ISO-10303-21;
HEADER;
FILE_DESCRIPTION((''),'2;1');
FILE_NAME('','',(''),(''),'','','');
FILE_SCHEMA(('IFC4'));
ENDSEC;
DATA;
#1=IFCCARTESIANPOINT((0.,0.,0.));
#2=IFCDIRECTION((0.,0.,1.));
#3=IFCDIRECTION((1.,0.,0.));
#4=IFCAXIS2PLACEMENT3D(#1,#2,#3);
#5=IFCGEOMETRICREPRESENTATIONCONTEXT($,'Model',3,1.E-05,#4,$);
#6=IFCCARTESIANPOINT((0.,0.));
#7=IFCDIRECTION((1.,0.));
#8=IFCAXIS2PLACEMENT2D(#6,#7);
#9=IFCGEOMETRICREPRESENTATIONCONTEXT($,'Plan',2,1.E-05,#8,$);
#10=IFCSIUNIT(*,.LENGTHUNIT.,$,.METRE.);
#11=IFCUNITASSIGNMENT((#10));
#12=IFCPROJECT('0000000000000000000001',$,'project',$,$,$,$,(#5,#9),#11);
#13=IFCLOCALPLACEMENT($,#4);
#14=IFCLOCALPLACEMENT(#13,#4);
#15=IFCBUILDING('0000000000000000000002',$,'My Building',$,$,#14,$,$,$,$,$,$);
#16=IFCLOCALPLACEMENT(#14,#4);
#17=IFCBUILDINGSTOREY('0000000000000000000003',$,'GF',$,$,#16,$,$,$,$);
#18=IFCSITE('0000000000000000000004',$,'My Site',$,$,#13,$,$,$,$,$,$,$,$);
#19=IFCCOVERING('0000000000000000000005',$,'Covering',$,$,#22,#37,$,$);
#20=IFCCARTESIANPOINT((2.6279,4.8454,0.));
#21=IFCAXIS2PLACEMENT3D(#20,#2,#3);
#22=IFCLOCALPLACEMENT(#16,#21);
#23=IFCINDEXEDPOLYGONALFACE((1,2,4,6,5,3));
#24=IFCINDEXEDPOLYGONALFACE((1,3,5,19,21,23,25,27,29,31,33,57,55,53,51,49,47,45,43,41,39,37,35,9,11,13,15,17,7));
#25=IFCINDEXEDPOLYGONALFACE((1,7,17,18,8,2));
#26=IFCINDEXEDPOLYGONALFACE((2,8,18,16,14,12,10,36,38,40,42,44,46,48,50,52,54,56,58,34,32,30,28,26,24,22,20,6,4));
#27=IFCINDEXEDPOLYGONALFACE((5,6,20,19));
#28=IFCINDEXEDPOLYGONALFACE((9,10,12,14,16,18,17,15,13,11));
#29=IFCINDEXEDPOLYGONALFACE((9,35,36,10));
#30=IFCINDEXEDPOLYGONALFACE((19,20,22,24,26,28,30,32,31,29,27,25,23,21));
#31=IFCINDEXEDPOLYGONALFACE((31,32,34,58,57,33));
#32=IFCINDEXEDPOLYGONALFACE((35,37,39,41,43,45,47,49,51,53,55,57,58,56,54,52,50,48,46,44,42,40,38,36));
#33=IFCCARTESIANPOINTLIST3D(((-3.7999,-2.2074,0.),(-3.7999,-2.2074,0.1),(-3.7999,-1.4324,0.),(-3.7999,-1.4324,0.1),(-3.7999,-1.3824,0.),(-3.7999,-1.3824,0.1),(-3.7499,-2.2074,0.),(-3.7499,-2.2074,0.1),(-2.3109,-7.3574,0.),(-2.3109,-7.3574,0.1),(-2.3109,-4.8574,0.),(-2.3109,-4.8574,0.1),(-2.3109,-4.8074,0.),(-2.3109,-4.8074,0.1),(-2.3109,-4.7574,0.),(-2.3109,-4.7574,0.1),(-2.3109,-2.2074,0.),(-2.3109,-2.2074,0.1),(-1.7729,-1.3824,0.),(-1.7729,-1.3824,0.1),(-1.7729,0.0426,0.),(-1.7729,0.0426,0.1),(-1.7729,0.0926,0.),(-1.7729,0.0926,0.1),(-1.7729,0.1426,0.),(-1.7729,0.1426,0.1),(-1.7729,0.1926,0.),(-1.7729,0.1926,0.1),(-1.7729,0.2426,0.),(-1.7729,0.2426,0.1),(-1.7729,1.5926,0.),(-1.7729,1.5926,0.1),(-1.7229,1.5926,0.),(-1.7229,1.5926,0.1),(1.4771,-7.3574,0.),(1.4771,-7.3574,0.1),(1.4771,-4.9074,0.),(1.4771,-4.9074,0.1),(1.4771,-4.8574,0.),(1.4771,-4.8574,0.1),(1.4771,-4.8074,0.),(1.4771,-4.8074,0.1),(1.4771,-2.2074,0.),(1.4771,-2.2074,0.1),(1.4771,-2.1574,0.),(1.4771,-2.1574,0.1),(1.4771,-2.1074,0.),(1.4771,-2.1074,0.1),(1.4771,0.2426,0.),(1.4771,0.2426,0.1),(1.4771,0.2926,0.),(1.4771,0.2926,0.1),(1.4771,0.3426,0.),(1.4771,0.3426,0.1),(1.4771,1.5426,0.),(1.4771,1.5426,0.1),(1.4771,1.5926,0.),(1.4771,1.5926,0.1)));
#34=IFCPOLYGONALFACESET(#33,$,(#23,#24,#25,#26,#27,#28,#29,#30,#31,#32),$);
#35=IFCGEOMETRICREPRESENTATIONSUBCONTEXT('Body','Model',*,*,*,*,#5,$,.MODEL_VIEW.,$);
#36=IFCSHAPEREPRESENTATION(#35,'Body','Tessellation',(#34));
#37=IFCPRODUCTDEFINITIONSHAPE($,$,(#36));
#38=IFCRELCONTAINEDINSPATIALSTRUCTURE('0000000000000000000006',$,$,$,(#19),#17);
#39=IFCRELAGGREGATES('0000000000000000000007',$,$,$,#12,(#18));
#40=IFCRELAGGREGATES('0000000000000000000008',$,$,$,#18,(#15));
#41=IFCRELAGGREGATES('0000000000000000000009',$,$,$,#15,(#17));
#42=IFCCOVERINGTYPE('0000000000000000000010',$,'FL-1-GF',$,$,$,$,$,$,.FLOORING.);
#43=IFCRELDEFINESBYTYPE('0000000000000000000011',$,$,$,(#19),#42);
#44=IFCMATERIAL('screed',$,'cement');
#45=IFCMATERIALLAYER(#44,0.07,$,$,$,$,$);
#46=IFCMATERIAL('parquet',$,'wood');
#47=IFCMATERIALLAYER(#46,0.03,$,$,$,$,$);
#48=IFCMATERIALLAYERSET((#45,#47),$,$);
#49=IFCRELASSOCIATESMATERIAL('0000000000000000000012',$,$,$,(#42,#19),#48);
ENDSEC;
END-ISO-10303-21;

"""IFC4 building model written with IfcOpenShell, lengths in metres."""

from ifc_helpers import new_model, si_unit, frame, origin_with_axes, origin_2d_with_axis, place, context, subcontext, project, spatial, line, indexed_curve, outline, extrude, material, layer, layer_set, layer_usage, type_object, element, save


model = new_model("IFC4")

# Units and contexts
model_context = context("Model", 3, precision=1e-05, world=origin_with_axes())
plan_context = context("Plan", 2, precision=1e-05, world=origin_2d_with_axis())
body_context_1 = subcontext(model_context, "Body", "Model", "MODEL_VIEW")
ifc_project = project(units=[si_unit("LENGTHUNIT", "METRE")], contexts=[model_context, plan_context])

# Site, building, storey
site_placement = place(None, origin_with_axes())
site = spatial("IfcSite", under=ifc_project, at=site_placement, Name="My Site")
building_placement = place(site_placement, origin_with_axes())
building = spatial("IfcBuilding", under=site, at=building_placement, Name="My Building")
storey_placement = place(building_placement, origin_with_axes())
storey = spatial("IfcBuildingStorey", under=building, at=storey_placement, Name="GF")

# Covering
ifc_material_1 = material(Name="screed", Category="cement")
ifc_layer_1 = layer(ifc_material_1, 0.07)
ifc_material_2 = material(Name="parquet", Category="wood")
ifc_layer_2 = layer(ifc_material_2, 0.03)
ifc_layer_set_1 = layer_set([ifc_layer_1, ifc_layer_2])
ifc_layer_usage_1 = layer_usage(ifc_layer_set_1, "AXIS3", "POSITIVE", 0.0)
covering_type = type_object("IfcCoveringType", Name="FL-1-GF", PredefinedType="FLOORING", material=ifc_layer_set_1)
covering_placement = place(storey_placement, frame((2.6279, 4.8454, 0.0), z_axis=(0.0, 0.0, 1.0), x_axis=(1.0, 0.0, 0.0)))
element("IfcCovering", 1, at=covering_placement, inside=storey, type_object=covering_type, material=ifc_layer_usage_1, Name="Covering", context=body_context_1, shape_type="SweptSolid", body=[
    extrude(outline(indexed_curve([(-1.7729, 1.5926), (-1.7229, 1.5926), (1.4771, 1.5926), (1.4771, 1.5426), (1.4771, 0.3426), (1.4771, 0.2926), (1.4771, 0.2426), (1.4771, -2.1074), (1.4771, -2.1574), (1.4771, -2.2074), (1.4771, -4.8074), (1.4771, -4.8574), (1.4771, -4.9074), (1.4771, -7.3574), (-2.3109, -7.3574), (-2.3109, -7.3574), (-2.3109, -4.8574), (-2.3109, -4.8074), (-2.3109, -4.7574), (-2.3109, -2.2074), (-3.7499, -2.2074), (-3.7999, -2.2074), (-3.7999, -1.4324), (-3.7999, -1.3824), (-1.7729, -1.3824), (-1.7729, 0.0426), (-1.7729, 0.0926), (-1.7729, 0.1426), (-1.7729, 0.1426), (-1.7729, 0.1926), (-1.7729, 0.2426)], segments=[line(1, 2, 3, 4, 5, 6, 7, 8, 9, 10, 11, 12, 13, 14, 15, 16, 17, 18, 19, 20, 21, 22, 23, 24, 25, 26, 27, 28, 29, 30, 31, 1)])), origin_with_axes(), (0.0, 0.0, 1.0), 0.1),
])

save(model, "model.ifc")
